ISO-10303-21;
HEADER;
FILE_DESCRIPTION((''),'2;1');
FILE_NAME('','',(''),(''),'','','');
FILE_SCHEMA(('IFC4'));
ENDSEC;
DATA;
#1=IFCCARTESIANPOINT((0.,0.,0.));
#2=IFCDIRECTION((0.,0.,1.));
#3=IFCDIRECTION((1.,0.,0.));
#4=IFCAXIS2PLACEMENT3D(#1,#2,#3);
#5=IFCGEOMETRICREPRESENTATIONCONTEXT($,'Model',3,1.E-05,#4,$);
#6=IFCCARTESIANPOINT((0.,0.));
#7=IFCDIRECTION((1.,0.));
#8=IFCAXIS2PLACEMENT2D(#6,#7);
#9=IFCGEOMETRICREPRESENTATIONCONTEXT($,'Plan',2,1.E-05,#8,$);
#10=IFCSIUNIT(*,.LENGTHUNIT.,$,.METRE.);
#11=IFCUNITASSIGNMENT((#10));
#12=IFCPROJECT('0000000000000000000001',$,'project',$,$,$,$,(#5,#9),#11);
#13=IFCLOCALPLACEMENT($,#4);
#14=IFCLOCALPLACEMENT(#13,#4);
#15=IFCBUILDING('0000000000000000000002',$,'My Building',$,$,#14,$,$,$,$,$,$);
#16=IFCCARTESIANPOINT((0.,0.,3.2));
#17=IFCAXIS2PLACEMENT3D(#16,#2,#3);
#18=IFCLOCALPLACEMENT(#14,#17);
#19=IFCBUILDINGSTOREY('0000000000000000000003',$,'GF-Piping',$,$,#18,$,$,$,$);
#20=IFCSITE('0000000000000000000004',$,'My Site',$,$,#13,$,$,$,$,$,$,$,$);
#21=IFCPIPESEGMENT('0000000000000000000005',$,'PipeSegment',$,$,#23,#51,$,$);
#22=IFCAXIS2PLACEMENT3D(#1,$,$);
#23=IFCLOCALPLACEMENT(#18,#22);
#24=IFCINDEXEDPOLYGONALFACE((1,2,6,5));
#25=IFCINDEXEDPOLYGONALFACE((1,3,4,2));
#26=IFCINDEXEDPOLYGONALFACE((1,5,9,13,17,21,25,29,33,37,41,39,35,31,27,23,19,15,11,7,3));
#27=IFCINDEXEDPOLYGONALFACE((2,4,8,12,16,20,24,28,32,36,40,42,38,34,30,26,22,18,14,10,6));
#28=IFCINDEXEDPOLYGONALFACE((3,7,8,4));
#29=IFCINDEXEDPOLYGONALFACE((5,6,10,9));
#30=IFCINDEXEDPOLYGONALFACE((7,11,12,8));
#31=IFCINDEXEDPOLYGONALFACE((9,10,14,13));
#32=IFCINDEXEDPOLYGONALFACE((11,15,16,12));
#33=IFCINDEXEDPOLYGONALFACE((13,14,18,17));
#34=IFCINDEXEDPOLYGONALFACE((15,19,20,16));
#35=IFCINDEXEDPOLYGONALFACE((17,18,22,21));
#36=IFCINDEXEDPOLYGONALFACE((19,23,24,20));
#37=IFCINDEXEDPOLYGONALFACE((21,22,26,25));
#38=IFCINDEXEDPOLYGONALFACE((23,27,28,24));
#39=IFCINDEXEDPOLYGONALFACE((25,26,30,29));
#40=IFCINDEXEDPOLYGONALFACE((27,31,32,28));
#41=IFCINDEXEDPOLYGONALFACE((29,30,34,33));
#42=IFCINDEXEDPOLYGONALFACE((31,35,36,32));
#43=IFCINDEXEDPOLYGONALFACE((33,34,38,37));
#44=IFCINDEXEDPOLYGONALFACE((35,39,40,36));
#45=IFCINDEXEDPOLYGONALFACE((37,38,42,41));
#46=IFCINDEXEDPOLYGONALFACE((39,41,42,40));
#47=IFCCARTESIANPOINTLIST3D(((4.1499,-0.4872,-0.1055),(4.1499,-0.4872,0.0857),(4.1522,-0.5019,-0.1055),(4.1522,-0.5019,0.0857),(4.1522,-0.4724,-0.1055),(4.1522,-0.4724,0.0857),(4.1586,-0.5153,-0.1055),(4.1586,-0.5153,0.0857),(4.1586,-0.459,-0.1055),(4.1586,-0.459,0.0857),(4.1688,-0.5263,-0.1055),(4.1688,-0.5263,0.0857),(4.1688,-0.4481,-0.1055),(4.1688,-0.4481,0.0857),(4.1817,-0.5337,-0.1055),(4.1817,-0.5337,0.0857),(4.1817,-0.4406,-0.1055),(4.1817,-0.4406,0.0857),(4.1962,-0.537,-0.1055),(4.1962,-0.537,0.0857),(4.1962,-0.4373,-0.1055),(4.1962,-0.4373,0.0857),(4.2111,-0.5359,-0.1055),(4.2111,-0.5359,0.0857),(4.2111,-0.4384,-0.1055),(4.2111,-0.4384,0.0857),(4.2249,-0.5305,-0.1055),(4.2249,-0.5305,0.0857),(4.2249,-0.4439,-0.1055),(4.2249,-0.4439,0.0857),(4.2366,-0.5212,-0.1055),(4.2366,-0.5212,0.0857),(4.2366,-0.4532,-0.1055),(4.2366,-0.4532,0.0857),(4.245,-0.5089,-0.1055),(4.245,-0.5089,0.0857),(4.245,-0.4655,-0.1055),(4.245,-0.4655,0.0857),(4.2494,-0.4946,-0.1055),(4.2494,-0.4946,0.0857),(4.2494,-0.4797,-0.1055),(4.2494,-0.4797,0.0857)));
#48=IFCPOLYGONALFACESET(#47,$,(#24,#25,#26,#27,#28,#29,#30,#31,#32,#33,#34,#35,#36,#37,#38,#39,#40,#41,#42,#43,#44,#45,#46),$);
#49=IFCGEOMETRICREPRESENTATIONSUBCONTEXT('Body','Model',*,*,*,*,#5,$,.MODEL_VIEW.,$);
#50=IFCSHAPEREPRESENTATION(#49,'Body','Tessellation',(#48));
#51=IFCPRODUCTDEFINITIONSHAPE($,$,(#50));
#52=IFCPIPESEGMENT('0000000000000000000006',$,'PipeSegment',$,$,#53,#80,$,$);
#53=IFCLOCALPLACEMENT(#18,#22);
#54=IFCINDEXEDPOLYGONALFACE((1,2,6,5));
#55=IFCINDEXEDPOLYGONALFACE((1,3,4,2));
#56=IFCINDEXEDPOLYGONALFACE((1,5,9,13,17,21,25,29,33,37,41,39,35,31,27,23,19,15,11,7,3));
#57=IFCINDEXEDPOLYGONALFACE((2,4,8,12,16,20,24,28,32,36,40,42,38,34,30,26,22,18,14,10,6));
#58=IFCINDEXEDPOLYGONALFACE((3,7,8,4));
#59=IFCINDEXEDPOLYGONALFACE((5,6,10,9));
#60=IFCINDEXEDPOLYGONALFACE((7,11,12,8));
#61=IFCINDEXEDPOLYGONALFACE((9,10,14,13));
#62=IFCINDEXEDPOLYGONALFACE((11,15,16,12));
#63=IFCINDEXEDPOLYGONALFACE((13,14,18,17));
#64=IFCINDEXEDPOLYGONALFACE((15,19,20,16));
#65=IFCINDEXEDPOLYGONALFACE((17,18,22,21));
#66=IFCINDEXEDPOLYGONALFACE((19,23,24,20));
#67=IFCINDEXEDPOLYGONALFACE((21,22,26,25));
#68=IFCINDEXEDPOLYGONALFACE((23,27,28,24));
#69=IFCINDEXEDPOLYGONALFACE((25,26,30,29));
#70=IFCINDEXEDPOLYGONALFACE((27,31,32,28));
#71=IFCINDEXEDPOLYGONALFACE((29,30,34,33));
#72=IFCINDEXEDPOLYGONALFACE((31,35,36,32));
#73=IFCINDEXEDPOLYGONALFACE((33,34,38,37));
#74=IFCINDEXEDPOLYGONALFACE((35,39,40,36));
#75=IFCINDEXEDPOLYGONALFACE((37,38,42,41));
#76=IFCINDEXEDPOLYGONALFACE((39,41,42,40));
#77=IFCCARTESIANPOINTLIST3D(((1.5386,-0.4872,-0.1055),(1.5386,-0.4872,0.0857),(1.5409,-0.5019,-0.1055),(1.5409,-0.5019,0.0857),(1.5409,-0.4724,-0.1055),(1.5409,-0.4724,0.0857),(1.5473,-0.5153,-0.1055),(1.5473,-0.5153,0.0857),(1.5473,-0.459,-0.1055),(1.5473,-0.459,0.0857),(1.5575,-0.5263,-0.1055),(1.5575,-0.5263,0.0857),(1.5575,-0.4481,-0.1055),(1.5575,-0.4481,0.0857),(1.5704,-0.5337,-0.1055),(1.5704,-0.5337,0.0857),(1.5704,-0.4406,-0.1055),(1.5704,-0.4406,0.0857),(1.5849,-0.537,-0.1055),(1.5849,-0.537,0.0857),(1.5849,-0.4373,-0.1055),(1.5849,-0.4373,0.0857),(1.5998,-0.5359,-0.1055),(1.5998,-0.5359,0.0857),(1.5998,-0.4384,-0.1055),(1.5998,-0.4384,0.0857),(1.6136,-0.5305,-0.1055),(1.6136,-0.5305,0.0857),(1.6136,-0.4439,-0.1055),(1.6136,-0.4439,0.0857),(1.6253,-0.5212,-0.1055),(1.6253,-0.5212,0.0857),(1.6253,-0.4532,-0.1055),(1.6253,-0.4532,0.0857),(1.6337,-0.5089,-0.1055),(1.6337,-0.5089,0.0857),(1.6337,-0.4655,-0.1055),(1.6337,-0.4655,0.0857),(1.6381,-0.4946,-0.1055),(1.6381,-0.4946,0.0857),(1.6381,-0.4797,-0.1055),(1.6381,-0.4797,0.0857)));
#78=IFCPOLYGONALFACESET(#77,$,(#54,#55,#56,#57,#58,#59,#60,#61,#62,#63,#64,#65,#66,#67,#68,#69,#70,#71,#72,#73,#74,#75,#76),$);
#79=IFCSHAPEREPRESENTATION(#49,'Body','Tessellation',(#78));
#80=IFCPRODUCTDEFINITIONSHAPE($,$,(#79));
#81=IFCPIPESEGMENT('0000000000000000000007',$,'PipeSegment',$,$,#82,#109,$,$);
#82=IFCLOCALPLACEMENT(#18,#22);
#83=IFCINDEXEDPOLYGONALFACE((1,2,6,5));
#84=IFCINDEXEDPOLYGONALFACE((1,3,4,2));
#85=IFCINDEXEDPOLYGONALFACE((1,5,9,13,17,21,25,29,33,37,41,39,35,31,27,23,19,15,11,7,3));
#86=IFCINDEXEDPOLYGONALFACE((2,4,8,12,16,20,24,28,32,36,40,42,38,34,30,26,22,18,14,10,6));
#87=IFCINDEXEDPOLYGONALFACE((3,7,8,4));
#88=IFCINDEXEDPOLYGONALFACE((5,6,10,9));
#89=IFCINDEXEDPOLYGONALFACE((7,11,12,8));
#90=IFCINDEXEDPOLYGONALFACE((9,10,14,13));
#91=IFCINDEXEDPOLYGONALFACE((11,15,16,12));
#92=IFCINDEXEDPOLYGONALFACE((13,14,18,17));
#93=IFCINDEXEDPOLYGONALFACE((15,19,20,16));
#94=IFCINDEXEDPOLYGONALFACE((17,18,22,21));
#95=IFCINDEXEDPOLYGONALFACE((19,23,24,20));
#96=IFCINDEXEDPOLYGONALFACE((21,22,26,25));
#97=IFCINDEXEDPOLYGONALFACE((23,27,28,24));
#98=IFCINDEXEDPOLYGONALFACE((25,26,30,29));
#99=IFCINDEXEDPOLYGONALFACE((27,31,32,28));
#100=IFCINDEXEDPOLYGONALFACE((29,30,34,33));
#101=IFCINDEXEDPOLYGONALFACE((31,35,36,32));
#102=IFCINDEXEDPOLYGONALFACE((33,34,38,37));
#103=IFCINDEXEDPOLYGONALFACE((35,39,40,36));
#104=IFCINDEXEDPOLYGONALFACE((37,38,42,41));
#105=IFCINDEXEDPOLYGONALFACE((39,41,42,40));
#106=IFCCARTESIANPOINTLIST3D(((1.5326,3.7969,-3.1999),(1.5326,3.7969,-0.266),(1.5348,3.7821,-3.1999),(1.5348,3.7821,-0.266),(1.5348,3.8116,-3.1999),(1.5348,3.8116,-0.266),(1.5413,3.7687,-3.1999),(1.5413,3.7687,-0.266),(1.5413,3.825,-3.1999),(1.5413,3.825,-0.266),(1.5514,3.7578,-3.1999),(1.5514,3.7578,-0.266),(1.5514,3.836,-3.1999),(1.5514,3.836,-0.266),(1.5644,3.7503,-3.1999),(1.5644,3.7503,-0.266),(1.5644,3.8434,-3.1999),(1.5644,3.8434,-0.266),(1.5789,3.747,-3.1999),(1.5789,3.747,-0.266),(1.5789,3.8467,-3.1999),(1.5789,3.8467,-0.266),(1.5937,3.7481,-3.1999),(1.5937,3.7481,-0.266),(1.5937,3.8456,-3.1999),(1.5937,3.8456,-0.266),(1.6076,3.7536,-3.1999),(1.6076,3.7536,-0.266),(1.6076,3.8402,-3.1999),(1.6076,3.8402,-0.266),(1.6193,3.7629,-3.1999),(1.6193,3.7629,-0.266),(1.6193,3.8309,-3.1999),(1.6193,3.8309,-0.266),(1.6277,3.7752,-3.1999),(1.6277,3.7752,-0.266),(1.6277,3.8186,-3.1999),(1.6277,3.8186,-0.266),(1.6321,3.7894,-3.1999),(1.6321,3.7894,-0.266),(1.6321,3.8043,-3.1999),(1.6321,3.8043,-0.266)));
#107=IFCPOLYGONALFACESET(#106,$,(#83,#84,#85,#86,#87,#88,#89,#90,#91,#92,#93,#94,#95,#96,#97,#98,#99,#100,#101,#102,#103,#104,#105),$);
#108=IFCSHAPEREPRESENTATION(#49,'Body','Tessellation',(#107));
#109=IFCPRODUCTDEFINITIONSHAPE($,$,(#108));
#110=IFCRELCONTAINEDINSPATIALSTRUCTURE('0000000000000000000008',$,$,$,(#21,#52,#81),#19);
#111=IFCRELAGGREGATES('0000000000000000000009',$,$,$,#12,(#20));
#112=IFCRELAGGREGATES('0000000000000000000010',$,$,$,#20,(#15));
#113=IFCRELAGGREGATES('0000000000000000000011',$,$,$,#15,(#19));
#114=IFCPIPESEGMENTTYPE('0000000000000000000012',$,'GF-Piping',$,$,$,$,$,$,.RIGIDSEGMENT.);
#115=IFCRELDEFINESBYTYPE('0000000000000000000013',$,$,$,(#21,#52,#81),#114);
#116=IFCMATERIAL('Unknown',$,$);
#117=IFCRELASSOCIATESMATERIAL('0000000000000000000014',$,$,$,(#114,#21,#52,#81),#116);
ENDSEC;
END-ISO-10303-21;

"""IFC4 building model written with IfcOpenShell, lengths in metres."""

from ifc_helpers import new_model, si_unit, frame, origin_with_axes, origin_2d_with_axis, place, context, subcontext, project, spatial, circle, extrude, material, material_profile, profile_set, profile_usage, type_object, element, save


model = new_model("IFC4")

# Units and contexts
model_context = context("Model", 3, precision=1e-05, world=origin_with_axes())
plan_context = context("Plan", 2, precision=1e-05, world=origin_2d_with_axis())
body_context = subcontext(model_context, "Body", "Model", "MODEL_VIEW")
ifc_project = project(units=[si_unit("LENGTHUNIT", "METRE")], contexts=[model_context, plan_context])

# Site, building, storey
site_placement = place(None, origin_with_axes())
site = spatial("IfcSite", under=ifc_project, at=site_placement, Name="My Site")
building_placement = place(site_placement, origin_with_axes())
building = spatial("IfcBuilding", under=site, at=building_placement, Name="My Building")
storey_placement = place(building_placement, frame((0.0, 0.0, 3.2), z_axis=(0.0, 0.0, 1.0), x_axis=(1.0, 0.0, 0.0)))
storey = spatial("IfcBuildingStorey", under=building, at=storey_placement, Name="GF-Piping")

# Pipe segments
ifc_material = material(Name="Unknown")
ifc_material_profile = material_profile(ifc_material, circle(Radius=0.05))
ifc_profile_set = profile_set([ifc_material_profile])
pipe_segment_type = type_object("IfcPipeSegmentType", Name="GF-Piping", PredefinedType="RIGIDSEGMENT", material=ifc_profile_set)
ifc_profile_usage_1 = profile_usage(ifc_profile_set, cardinal=5)
pipe_segment_1_placement = place(storey_placement, frame((4.1999, -0.4872, 0.0857), z_axis=(0.0, 0.0, -1.0), x_axis=(-1.0, 0.0, 0.0)))
element("IfcPipeSegment", 1, at=pipe_segment_1_placement, inside=storey, type_object=pipe_segment_type, material=ifc_profile_usage_1, Name="PipeSegment", context=body_context, shape_type="SweptSolid", body=[
    extrude(circle(Radius=0.05), origin_with_axes(), (0.0, 0.0, 1.0), 0.1912),
])
ifc_profile_usage_2 = profile_usage(ifc_profile_set, cardinal=5)
pipe_segment_2_placement = place(storey_placement, frame((1.5886, -0.4872, 0.0857), z_axis=(0.0, 0.0, -1.0), x_axis=(-1.0, 0.0, 0.0)))
element("IfcPipeSegment", 2, at=pipe_segment_2_placement, inside=storey, type_object=pipe_segment_type, material=ifc_profile_usage_2, Name="PipeSegment", context=body_context, shape_type="SweptSolid", body=[
    extrude(circle(Radius=0.05), origin_with_axes(), (0.0, 0.0, 1.0), 0.1912),
])
ifc_profile_usage_3 = profile_usage(ifc_profile_set, cardinal=5)
pipe_segment_3_placement = place(storey_placement, frame((1.5826, 3.7969, -0.266), z_axis=(0.0, 0.0, -1.0), x_axis=(-1.0, 0.0, 0.0)))
element("IfcPipeSegment", 3, at=pipe_segment_3_placement, inside=storey, type_object=pipe_segment_type, material=ifc_profile_usage_3, Name="PipeSegment", context=body_context, shape_type="SweptSolid", body=[
    extrude(circle(Radius=0.05), origin_with_axes(), (0.0, 0.0, 1.0), 2.934),
])

save(model, "model.ifc")
